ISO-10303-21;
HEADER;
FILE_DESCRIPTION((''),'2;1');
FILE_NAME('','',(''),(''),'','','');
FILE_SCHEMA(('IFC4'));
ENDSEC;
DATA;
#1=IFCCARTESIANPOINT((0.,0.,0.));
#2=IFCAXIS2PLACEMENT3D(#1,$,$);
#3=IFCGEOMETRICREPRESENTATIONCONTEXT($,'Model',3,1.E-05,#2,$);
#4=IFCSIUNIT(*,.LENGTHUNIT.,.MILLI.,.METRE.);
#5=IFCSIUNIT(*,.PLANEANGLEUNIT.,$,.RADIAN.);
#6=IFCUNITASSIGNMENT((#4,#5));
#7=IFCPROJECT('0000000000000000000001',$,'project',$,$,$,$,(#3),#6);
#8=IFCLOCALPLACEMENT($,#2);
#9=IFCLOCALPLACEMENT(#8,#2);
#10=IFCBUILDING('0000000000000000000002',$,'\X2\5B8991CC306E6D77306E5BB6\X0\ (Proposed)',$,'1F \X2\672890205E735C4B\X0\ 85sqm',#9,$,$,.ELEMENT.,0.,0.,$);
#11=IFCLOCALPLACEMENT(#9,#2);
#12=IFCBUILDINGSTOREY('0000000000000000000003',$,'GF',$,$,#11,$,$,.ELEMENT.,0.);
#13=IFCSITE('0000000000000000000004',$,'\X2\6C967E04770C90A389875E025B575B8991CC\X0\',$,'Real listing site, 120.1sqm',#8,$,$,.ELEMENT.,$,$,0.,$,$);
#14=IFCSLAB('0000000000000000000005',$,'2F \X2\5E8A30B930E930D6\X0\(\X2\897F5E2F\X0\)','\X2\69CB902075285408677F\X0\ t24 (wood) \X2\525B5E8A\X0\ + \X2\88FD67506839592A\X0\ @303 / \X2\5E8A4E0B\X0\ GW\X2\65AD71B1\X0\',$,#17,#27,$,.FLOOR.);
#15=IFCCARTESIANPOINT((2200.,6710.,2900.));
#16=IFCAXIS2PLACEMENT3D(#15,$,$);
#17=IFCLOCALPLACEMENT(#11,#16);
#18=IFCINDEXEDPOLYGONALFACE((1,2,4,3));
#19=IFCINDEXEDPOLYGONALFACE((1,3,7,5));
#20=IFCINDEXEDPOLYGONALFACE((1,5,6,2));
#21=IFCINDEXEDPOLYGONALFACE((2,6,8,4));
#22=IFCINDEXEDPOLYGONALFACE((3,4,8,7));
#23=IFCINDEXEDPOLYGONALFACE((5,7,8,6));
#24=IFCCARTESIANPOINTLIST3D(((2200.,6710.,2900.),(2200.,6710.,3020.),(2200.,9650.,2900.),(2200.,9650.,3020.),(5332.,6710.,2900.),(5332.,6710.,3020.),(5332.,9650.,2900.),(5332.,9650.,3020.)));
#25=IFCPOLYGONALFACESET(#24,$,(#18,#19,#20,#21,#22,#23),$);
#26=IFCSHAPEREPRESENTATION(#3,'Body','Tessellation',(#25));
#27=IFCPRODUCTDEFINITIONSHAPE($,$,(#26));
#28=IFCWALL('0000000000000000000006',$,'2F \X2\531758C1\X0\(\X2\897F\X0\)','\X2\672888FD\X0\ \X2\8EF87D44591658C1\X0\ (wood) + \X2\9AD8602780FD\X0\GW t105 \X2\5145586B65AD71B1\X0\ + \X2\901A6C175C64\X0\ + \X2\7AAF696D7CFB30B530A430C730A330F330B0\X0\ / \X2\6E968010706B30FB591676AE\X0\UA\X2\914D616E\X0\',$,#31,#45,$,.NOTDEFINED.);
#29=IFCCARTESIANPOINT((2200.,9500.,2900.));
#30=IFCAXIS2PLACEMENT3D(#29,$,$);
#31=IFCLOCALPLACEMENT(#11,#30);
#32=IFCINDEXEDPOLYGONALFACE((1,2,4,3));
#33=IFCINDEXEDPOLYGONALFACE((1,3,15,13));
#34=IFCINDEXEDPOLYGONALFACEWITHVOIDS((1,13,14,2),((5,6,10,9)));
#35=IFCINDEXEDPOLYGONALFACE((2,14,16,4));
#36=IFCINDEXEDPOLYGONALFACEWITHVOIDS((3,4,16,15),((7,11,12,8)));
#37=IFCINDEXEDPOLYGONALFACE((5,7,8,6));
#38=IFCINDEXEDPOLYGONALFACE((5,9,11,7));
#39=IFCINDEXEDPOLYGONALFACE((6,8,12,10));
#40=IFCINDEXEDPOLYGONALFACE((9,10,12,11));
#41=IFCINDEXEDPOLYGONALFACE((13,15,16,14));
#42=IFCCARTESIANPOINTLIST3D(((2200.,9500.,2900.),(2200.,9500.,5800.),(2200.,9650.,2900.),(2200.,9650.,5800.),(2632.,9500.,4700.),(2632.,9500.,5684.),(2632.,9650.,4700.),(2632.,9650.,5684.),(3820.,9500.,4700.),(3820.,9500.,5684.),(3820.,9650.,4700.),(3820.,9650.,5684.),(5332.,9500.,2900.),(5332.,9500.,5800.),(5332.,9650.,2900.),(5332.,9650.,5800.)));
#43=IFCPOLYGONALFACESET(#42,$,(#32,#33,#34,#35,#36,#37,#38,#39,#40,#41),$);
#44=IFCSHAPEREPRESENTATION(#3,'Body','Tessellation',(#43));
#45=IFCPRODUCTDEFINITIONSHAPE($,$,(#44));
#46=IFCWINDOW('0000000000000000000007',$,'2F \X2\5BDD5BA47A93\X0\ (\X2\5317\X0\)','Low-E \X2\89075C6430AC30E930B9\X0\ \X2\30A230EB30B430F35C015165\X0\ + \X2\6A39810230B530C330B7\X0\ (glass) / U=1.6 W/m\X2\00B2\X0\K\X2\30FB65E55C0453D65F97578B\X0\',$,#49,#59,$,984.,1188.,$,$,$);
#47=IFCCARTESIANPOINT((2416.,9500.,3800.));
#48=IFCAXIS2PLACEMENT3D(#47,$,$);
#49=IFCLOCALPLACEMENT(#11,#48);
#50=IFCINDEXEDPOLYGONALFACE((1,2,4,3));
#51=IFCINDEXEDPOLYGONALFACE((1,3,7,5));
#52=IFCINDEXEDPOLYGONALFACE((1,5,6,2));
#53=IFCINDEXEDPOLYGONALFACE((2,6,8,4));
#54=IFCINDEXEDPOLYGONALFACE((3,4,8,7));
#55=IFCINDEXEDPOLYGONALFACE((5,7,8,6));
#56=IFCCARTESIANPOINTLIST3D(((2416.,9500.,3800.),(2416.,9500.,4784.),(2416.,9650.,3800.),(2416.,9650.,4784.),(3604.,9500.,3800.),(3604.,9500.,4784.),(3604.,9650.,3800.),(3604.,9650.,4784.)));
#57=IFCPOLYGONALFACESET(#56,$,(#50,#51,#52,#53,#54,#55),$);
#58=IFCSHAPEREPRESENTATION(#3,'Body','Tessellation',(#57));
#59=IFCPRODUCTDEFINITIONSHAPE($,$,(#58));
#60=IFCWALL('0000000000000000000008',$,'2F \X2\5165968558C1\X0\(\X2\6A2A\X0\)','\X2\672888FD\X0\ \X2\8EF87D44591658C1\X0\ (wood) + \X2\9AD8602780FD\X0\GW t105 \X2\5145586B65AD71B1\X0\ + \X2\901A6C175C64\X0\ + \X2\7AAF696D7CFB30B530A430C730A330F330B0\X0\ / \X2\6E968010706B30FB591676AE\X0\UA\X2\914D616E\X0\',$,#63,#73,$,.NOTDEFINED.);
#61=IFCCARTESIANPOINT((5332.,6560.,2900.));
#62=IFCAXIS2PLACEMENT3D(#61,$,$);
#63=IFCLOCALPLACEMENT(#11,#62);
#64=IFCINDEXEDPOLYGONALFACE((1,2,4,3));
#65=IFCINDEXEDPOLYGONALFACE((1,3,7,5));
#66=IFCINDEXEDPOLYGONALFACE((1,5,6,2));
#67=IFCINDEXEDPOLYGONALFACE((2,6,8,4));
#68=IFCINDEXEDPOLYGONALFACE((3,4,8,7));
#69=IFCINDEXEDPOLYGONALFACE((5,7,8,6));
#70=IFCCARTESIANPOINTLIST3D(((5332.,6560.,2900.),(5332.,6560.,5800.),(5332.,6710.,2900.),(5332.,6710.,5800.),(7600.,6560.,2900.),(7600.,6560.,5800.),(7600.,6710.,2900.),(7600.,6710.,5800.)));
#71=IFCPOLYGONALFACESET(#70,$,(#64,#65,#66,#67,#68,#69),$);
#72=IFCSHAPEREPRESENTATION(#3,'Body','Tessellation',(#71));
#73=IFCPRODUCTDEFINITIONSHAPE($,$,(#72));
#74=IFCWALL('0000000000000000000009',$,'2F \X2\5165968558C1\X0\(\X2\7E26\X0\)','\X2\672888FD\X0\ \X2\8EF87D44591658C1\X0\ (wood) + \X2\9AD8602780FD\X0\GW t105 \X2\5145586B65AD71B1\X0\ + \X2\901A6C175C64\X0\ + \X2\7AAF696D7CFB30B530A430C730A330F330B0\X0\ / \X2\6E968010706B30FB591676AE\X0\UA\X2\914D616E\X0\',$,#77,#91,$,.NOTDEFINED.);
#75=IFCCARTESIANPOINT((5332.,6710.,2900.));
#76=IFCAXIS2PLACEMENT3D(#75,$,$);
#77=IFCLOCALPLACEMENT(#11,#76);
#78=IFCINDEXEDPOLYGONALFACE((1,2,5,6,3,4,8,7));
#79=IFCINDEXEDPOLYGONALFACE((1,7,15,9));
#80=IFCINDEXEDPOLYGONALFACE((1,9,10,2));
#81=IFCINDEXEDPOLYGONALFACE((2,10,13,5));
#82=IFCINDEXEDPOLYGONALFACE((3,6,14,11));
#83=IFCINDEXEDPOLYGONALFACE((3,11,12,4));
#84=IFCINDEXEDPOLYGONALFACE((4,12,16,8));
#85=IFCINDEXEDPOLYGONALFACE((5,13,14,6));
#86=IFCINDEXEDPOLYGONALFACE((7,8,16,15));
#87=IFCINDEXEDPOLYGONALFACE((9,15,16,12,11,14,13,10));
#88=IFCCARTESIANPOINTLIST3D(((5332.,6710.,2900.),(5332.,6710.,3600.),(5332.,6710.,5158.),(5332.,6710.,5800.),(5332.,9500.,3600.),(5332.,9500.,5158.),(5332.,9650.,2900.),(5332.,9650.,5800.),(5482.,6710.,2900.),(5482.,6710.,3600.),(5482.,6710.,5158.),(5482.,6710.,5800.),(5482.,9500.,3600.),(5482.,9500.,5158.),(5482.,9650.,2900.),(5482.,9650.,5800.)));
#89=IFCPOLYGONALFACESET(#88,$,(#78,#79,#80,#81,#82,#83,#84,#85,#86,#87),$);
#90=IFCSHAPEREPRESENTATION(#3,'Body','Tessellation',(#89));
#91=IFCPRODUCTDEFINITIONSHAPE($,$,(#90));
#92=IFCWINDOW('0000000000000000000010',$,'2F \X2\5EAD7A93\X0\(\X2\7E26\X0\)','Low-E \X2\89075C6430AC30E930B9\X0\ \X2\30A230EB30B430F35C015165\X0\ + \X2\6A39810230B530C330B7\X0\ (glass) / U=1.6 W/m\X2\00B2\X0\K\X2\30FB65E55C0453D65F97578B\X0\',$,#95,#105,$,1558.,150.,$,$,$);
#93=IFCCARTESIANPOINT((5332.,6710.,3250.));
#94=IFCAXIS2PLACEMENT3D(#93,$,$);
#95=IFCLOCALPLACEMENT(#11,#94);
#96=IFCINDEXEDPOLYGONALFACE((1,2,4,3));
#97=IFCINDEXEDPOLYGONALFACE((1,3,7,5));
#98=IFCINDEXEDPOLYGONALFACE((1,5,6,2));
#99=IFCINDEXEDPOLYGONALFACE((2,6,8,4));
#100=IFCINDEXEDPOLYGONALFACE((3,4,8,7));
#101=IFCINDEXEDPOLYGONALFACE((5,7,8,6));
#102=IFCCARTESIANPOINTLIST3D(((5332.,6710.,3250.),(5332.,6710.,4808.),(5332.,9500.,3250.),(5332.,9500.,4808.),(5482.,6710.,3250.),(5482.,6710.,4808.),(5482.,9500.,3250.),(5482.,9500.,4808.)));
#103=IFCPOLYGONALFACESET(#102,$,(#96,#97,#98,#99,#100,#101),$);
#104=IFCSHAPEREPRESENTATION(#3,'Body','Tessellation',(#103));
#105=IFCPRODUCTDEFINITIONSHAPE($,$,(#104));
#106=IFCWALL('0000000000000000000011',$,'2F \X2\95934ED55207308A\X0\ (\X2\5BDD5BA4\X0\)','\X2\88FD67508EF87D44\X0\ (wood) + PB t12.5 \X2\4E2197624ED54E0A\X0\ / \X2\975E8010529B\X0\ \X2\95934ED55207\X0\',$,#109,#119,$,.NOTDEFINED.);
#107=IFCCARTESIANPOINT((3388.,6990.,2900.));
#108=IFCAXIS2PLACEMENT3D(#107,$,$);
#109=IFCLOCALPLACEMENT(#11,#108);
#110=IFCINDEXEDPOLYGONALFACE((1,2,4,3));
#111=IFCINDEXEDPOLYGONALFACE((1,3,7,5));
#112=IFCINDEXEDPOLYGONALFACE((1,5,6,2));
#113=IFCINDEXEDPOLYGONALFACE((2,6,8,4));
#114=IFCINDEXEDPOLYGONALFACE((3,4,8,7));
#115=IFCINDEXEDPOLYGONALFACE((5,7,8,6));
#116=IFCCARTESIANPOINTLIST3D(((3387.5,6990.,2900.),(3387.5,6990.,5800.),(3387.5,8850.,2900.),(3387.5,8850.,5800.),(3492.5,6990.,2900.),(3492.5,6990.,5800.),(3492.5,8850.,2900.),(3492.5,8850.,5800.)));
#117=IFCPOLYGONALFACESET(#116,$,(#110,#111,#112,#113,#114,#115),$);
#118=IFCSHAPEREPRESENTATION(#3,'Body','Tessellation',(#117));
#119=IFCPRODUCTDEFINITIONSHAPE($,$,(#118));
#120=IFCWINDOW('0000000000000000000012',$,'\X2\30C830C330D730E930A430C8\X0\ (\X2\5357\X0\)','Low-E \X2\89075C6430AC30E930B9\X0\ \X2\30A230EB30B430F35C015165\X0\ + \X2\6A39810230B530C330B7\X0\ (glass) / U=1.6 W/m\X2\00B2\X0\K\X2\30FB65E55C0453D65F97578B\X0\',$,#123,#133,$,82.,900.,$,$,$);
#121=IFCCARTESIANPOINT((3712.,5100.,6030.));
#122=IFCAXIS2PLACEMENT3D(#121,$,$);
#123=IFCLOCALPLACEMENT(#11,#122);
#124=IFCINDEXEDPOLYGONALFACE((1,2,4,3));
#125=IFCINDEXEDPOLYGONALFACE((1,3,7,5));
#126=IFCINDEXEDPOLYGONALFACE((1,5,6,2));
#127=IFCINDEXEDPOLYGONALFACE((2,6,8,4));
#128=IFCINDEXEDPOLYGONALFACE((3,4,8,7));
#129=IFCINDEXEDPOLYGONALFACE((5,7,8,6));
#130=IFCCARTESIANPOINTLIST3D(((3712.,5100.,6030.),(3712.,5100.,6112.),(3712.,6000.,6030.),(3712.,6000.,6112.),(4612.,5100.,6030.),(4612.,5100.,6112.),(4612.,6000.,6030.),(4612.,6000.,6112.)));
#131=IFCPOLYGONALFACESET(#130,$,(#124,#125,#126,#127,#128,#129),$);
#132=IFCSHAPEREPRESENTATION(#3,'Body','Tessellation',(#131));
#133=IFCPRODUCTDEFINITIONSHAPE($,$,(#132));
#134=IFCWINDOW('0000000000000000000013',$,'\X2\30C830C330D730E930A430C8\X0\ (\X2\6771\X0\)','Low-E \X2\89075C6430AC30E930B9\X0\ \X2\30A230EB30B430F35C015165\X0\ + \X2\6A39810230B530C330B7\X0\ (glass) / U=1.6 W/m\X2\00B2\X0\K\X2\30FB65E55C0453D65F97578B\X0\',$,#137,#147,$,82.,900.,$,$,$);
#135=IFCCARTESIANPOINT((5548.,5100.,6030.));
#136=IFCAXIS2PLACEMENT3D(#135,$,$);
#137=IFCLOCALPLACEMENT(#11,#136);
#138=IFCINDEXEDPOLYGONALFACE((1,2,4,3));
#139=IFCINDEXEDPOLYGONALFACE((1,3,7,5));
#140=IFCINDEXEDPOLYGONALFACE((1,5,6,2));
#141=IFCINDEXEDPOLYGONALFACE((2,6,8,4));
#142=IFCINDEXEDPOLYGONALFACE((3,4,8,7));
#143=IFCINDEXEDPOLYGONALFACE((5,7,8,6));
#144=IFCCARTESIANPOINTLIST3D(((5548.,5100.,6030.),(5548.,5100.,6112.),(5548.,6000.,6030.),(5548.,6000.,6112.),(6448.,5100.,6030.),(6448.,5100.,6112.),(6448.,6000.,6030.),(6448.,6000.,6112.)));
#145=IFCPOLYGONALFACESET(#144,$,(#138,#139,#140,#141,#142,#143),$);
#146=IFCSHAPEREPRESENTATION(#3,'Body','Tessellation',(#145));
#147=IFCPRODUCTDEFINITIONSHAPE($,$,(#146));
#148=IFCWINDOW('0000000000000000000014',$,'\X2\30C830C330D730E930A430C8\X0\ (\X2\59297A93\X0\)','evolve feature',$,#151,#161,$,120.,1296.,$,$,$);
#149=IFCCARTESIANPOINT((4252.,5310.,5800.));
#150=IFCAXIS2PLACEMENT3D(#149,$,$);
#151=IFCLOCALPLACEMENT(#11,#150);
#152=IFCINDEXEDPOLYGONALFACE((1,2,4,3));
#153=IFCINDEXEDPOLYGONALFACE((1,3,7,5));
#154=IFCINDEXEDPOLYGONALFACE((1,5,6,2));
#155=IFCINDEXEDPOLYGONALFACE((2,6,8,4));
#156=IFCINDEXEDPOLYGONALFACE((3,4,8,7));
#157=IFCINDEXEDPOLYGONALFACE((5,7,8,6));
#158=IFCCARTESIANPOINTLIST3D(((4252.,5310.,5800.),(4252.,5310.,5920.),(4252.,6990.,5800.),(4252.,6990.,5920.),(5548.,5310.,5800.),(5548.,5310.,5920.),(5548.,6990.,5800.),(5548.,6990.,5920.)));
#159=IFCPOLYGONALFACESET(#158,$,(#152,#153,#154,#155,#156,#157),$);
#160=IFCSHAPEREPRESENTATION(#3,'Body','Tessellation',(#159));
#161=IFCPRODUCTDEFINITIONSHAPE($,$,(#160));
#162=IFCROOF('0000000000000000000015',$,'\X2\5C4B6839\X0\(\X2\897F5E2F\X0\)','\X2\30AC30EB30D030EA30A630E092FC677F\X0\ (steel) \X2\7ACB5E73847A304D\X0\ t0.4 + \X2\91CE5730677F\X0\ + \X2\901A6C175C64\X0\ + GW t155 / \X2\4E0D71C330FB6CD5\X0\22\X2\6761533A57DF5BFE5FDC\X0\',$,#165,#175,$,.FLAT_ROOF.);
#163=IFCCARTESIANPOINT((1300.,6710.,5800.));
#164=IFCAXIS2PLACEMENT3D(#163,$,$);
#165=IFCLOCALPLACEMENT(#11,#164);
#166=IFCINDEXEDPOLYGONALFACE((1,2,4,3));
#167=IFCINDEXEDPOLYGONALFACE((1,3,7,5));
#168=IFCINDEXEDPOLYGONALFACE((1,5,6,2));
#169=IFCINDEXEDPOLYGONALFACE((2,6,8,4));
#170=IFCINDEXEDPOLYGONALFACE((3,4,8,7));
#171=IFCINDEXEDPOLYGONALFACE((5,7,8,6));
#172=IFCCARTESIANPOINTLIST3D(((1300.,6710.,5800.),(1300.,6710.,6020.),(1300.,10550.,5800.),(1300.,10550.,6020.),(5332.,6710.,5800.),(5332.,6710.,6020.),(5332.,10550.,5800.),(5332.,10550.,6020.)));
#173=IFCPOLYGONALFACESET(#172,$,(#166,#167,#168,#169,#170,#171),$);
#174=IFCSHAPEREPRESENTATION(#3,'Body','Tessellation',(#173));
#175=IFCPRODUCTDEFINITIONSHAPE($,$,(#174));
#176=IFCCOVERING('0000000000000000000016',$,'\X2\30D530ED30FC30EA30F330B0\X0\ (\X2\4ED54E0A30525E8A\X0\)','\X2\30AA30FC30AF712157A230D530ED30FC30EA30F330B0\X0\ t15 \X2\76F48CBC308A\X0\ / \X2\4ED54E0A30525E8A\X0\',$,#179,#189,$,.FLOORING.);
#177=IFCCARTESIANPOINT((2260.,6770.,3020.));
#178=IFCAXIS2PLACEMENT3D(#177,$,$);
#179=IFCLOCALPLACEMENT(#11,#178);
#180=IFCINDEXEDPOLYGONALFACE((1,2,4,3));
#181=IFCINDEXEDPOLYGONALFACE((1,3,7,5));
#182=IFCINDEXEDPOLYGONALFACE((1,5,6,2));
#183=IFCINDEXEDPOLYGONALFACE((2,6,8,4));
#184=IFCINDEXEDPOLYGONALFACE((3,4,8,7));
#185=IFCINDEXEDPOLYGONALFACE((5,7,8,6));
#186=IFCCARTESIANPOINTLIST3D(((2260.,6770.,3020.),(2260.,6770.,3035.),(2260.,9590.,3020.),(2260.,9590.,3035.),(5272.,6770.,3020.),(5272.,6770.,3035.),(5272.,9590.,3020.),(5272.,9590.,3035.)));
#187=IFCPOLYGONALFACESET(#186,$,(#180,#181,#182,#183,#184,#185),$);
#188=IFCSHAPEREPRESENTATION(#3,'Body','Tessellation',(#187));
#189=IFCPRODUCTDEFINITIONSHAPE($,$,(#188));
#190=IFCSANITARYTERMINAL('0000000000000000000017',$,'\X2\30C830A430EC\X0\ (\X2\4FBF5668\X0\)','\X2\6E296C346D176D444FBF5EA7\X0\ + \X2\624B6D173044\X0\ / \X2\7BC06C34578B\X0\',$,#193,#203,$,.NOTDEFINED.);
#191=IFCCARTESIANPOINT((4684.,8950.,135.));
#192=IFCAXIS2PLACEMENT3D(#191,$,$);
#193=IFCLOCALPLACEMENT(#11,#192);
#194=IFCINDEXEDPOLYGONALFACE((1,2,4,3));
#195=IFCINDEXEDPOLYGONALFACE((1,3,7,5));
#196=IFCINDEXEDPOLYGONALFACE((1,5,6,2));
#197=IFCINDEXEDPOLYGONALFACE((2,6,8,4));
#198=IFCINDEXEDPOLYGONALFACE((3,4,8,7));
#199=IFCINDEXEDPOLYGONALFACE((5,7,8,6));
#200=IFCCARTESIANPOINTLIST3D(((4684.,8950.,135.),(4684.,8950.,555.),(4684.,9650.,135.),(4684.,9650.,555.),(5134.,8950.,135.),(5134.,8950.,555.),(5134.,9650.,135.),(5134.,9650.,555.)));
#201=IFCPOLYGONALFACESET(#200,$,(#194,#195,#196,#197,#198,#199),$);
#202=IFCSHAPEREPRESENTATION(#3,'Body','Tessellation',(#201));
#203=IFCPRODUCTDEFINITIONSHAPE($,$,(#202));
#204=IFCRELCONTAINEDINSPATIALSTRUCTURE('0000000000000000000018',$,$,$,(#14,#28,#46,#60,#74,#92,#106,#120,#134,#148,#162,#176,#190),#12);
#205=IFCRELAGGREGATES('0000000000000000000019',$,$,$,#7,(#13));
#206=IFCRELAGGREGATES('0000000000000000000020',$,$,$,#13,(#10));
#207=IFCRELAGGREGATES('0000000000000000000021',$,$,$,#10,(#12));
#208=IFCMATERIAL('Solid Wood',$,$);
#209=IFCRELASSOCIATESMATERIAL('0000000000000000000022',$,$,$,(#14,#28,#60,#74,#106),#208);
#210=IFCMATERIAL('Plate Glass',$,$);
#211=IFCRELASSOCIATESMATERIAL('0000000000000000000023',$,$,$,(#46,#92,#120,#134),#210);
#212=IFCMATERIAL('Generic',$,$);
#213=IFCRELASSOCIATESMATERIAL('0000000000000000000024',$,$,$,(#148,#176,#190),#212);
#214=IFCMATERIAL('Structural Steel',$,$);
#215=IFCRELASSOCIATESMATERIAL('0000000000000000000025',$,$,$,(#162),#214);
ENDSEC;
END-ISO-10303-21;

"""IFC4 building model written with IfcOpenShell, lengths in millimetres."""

from ifc_helpers import new_model, si_unit, frame, frame_2d, origin, place, context, project, spatial, rectangle, extrude, material, element, fill, save


model = new_model("IFC4")

# Units and contexts
model_context = context("Model", 3, precision=1e-05, world=origin())
ifc_project = project(units=[si_unit("LENGTHUNIT", "METRE", prefix="MILLI"), si_unit("PLANEANGLEUNIT", "RADIAN")], contexts=[model_context])

# Site, building, storey
site_placement = place(None, origin())
site = spatial("IfcSite", under=ifc_project, at=site_placement, Name="沖縄県那覇市字安里", ObjectType="Real listing site, 120.1sqm", CompositionType="ELEMENT", RefElevation=0.0)
building_placement = place(site_placement, origin())
building = spatial("IfcBuilding", under=site, at=building_placement, Name="安里の海の家 (Proposed)", ObjectType="1F 木造平屋 85sqm", CompositionType="ELEMENT", ElevationOfRefHeight=0.0, ElevationOfTerrain=0.0)
storey_placement = place(building_placement, origin())
storey = spatial("IfcBuildingStorey", under=building, at=storey_placement, Name="GF", CompositionType="ELEMENT", Elevation=0.0)

# Slab
ifc_material_1 = material(Name="Solid Wood")
slab_placement = place(storey_placement, frame((2200.0, 6710.0, 2900.0)))
element("IfcSlab", 1, at=slab_placement, inside=storey, material=ifc_material_1, Name="2F 床スラブ(西帯)", Description="構造用合板 t24 (wood) 剛床 + 製材根太 @303 / 床下 GW断熱", PredefinedType="FLOOR", context=model_context, shape_type="SweptSolid", body=[
    extrude(rectangle(XDim=3132.0, YDim=2940.0, at=frame_2d((1566.0, 1470.0))), frame((2200.0, 6710.0, 2900.0)), (0.0, 0.0, 1.0), 120.0),
])

# Wall, opening, window
wall_1_placement = place(storey_placement, frame((2200.0, 9500.0, 2900.0)))
wall_1 = element("IfcWall", 2, at=wall_1_placement, inside=storey, material=ifc_material_1, Name="2F 北壁(西)", Description="木製 軸組外壁 (wood) + 高性能GW t105 充填断熱 + 通気層 + 窯業系サイディング / 準耐火・外皮UA配慮", PredefinedType="NOTDEFINED", context=model_context, shape_type="SweptSolid", body=[
    extrude(rectangle(XDim=3132.0, YDim=150.0, at=frame_2d((1566.0, 75.0))), frame((2200.0, 9500.0, 2900.0)), (0.0, 0.0, 1.0), 2900.0),
])
opening_1_placement = place(storey_placement, frame((2416.0, 9500.0, 3800.0)))
opening_1 = element("IfcOpeningElement", 3, at=opening_1_placement, cuts=wall_1, PredefinedType="NOTDEFINED", context=model_context, shape_type="SweptSolid", body=[
    extrude(rectangle(XDim=1188.0, YDim=150.0, at=frame_2d((594.0, 75.0))), frame((2416.0, 9500.0, 3800.0)), (0.0, 0.0, 1.0), 984.0),
])
ifc_material_2 = material(Name="Plate Glass")
window_1_placement = place(storey_placement, frame((2416.0, 9500.0, 3800.0)))
window_1 = element("IfcWindow", 4, at=window_1_placement, inside=storey, material=ifc_material_2, Name="2F 寝室窓 (北)", Description="Low-E 複層ガラス アルゴン封入 + 樹脂サッシ (glass) / U=1.6 W/m²K・日射取得型", OverallHeight=984.0, OverallWidth=1188.0, context=model_context, shape_type="SweptSolid", body=[
    extrude(rectangle(XDim=1188.0, YDim=150.0, at=frame_2d((594.0, 75.0))), frame((2416.0, 9500.0, 3800.0)), (0.0, 0.0, 1.0), 984.0),
])
fill(opening_1, window_1)

# Wall
wall_2_placement = place(storey_placement, frame((5332.0, 6560.0, 2900.0)))
element("IfcWall", 5, at=wall_2_placement, inside=storey, material=ifc_material_1, Name="2F 入隅壁(横)", Description="木製 軸組外壁 (wood) + 高性能GW t105 充填断熱 + 通気層 + 窯業系サイディング / 準耐火・外皮UA配慮", PredefinedType="NOTDEFINED", context=model_context, shape_type="SweptSolid", body=[
    extrude(rectangle(XDim=2268.0, YDim=150.0, at=frame_2d((1134.0, 75.0))), frame((5332.0, 6560.0, 2900.0)), (0.0, 0.0, 1.0), 2900.0),
])

# Wall, opening, window
wall_3_placement = place(storey_placement, frame((5332.0, 6710.0, 2900.0)))
wall_3 = element("IfcWall", 6, at=wall_3_placement, inside=storey, material=ifc_material_1, Name="2F 入隅壁(縦)", Description="木製 軸組外壁 (wood) + 高性能GW t105 充填断熱 + 通気層 + 窯業系サイディング / 準耐火・外皮UA配慮", PredefinedType="NOTDEFINED", context=model_context, shape_type="SweptSolid", body=[
    extrude(rectangle(XDim=150.0, YDim=2940.0, at=frame_2d((75.0, 1470.0))), frame((5332.0, 6710.0, 2900.0)), (0.0, 0.0, 1.0), 2900.0),
])
opening_2_placement = place(storey_placement, frame((5332.0, 6710.0, 3250.0)))
opening_2 = element("IfcOpeningElement", 7, at=opening_2_placement, cuts=wall_3, PredefinedType="NOTDEFINED", context=model_context, shape_type="SweptSolid", body=[
    extrude(rectangle(XDim=150.0, YDim=2790.0, at=frame_2d((75.0, 1395.0))), frame((5332.0, 6710.0, 3250.0)), (0.0, 0.0, 1.0), 1558.0),
])
window_2_placement = place(storey_placement, frame((5332.0, 6710.0, 3250.0)))
window_2 = element("IfcWindow", 8, at=window_2_placement, inside=storey, material=ifc_material_2, Name="2F 庭窓(縦)", Description="Low-E 複層ガラス アルゴン封入 + 樹脂サッシ (glass) / U=1.6 W/m²K・日射取得型", OverallHeight=1558.0, OverallWidth=150.0, context=model_context, shape_type="SweptSolid", body=[
    extrude(rectangle(XDim=150.0, YDim=2790.0, at=frame_2d((75.0, 1395.0))), frame((5332.0, 6710.0, 3250.0)), (0.0, 0.0, 1.0), 1558.0),
])
fill(opening_2, window_2)

# Wall
wall_4_placement = place(storey_placement, frame((3388.0, 6990.0, 2900.0)))
element("IfcWall", 9, at=wall_4_placement, inside=storey, material=ifc_material_1, Name="2F 間仕切り (寝室)", Description="製材軸組 (wood) + PB t12.5 両面仕上 / 非耐力 間仕切", PredefinedType="NOTDEFINED", context=model_context, shape_type="SweptSolid", body=[
    extrude(rectangle(XDim=105.0, YDim=1860.0, at=frame_2d((52.0, 930.0))), frame((3388.0, 6990.0, 2900.0)), (0.0, 0.0, 1.0), 2900.0),
])

# Windows
window_3_placement = place(storey_placement, frame((3712.0, 5100.0, 6030.0)))
element("IfcWindow", 10, at=window_3_placement, inside=storey, material=ifc_material_2, Name="トップライト (南)", Description="Low-E 複層ガラス アルゴン封入 + 樹脂サッシ (glass) / U=1.6 W/m²K・日射取得型", OverallHeight=82.0, OverallWidth=900.0, context=model_context, shape_type="SweptSolid", body=[
    extrude(rectangle(XDim=900.0, YDim=900.0, at=frame_2d((450.0, 450.0))), frame((3712.0, 5100.0, 6030.0)), (0.0, 0.0, 1.0), 82.0),
])
window_4_placement = place(storey_placement, frame((5548.0, 5100.0, 6030.0)))
element("IfcWindow", 11, at=window_4_placement, inside=storey, material=ifc_material_2, Name="トップライト (東)", Description="Low-E 複層ガラス アルゴン封入 + 樹脂サッシ (glass) / U=1.6 W/m²K・日射取得型", OverallHeight=82.0, OverallWidth=900.0, context=model_context, shape_type="SweptSolid", body=[
    extrude(rectangle(XDim=900.0, YDim=900.0, at=frame_2d((450.0, 450.0))), frame((5548.0, 5100.0, 6030.0)), (0.0, 0.0, 1.0), 82.0),
])
ifc_material_3 = material(Name="Generic")
window_5_placement = place(storey_placement, frame((4252.0, 5310.0, 5800.0)))
element("IfcWindow", 12, at=window_5_placement, inside=storey, material=ifc_material_3, Name="トップライト (天窓)", Description="evolve feature", OverallHeight=120.0, OverallWidth=1296.0, context=model_context, shape_type="SweptSolid", body=[
    extrude(rectangle(XDim=1296.0, YDim=1680.0, at=frame_2d((648.0, 840.0))), frame((4252.0, 5310.0, 5800.0)), (0.0, 0.0, 1.0), 120.0),
])

# Roof
ifc_material_4 = material(Name="Structural Steel")
for number, where, name in (
    (13, (1300.0, 6710.0, 5800.0), "屋根(西帯)"),
):
    element("IfcRoof", number, at=place(storey_placement, frame(where)), inside=storey, material=ifc_material_4, Name=name, Description="ガルバリウム鋼板 (steel) 立平葺き t0.4 + 野地板 + 通気層 + GW t155 / 不燃・法22条区域対応", PredefinedType="FLAT_ROOF", context=model_context, shape_type="SweptSolid", body=[
        extrude(rectangle(XDim=4032.0, YDim=3840.0, at=frame_2d((2016.0, 1920.0))), frame((1300.0, 6710.0, 5800.0)), (0.0, 0.0, 1.0), 220.0),
    ])

# Covering
covering_placement = place(storey_placement, frame((2260.0, 6770.0, 3020.0)))
element("IfcCovering", 14, at=covering_placement, inside=storey, material=ifc_material_3, Name="フローリング (仕上げ床)", Description="オーク無垢フローリング t15 直貼り / 仕上げ床", PredefinedType="FLOORING", context=model_context, shape_type="SweptSolid", body=[
    extrude(rectangle(XDim=3012.0, YDim=2820.0, at=frame_2d((1506.0, 1410.0))), frame((2260.0, 6770.0, 3020.0)), (0.0, 0.0, 1.0), 15.0),
])

# Sanitary terminal
sanitary_terminal_placement = place(storey_placement, frame((4684.0, 8950.0, 135.0)))
element("IfcSanitaryTerminal", 15, at=sanitary_terminal_placement, inside=storey, material=ifc_material_3, Name="トイレ (便器)", Description="温水洗浄便座 + 手洗い / 節水型", PredefinedType="NOTDEFINED", context=model_context, shape_type="SweptSolid", body=[
    extrude(rectangle(XDim=450.0, YDim=700.0, at=frame_2d((225.0, 350.0))), frame((4684.0, 8950.0, 135.0)), (0.0, 0.0, 1.0), 420.0),
])

save(model, "model.ifc")
